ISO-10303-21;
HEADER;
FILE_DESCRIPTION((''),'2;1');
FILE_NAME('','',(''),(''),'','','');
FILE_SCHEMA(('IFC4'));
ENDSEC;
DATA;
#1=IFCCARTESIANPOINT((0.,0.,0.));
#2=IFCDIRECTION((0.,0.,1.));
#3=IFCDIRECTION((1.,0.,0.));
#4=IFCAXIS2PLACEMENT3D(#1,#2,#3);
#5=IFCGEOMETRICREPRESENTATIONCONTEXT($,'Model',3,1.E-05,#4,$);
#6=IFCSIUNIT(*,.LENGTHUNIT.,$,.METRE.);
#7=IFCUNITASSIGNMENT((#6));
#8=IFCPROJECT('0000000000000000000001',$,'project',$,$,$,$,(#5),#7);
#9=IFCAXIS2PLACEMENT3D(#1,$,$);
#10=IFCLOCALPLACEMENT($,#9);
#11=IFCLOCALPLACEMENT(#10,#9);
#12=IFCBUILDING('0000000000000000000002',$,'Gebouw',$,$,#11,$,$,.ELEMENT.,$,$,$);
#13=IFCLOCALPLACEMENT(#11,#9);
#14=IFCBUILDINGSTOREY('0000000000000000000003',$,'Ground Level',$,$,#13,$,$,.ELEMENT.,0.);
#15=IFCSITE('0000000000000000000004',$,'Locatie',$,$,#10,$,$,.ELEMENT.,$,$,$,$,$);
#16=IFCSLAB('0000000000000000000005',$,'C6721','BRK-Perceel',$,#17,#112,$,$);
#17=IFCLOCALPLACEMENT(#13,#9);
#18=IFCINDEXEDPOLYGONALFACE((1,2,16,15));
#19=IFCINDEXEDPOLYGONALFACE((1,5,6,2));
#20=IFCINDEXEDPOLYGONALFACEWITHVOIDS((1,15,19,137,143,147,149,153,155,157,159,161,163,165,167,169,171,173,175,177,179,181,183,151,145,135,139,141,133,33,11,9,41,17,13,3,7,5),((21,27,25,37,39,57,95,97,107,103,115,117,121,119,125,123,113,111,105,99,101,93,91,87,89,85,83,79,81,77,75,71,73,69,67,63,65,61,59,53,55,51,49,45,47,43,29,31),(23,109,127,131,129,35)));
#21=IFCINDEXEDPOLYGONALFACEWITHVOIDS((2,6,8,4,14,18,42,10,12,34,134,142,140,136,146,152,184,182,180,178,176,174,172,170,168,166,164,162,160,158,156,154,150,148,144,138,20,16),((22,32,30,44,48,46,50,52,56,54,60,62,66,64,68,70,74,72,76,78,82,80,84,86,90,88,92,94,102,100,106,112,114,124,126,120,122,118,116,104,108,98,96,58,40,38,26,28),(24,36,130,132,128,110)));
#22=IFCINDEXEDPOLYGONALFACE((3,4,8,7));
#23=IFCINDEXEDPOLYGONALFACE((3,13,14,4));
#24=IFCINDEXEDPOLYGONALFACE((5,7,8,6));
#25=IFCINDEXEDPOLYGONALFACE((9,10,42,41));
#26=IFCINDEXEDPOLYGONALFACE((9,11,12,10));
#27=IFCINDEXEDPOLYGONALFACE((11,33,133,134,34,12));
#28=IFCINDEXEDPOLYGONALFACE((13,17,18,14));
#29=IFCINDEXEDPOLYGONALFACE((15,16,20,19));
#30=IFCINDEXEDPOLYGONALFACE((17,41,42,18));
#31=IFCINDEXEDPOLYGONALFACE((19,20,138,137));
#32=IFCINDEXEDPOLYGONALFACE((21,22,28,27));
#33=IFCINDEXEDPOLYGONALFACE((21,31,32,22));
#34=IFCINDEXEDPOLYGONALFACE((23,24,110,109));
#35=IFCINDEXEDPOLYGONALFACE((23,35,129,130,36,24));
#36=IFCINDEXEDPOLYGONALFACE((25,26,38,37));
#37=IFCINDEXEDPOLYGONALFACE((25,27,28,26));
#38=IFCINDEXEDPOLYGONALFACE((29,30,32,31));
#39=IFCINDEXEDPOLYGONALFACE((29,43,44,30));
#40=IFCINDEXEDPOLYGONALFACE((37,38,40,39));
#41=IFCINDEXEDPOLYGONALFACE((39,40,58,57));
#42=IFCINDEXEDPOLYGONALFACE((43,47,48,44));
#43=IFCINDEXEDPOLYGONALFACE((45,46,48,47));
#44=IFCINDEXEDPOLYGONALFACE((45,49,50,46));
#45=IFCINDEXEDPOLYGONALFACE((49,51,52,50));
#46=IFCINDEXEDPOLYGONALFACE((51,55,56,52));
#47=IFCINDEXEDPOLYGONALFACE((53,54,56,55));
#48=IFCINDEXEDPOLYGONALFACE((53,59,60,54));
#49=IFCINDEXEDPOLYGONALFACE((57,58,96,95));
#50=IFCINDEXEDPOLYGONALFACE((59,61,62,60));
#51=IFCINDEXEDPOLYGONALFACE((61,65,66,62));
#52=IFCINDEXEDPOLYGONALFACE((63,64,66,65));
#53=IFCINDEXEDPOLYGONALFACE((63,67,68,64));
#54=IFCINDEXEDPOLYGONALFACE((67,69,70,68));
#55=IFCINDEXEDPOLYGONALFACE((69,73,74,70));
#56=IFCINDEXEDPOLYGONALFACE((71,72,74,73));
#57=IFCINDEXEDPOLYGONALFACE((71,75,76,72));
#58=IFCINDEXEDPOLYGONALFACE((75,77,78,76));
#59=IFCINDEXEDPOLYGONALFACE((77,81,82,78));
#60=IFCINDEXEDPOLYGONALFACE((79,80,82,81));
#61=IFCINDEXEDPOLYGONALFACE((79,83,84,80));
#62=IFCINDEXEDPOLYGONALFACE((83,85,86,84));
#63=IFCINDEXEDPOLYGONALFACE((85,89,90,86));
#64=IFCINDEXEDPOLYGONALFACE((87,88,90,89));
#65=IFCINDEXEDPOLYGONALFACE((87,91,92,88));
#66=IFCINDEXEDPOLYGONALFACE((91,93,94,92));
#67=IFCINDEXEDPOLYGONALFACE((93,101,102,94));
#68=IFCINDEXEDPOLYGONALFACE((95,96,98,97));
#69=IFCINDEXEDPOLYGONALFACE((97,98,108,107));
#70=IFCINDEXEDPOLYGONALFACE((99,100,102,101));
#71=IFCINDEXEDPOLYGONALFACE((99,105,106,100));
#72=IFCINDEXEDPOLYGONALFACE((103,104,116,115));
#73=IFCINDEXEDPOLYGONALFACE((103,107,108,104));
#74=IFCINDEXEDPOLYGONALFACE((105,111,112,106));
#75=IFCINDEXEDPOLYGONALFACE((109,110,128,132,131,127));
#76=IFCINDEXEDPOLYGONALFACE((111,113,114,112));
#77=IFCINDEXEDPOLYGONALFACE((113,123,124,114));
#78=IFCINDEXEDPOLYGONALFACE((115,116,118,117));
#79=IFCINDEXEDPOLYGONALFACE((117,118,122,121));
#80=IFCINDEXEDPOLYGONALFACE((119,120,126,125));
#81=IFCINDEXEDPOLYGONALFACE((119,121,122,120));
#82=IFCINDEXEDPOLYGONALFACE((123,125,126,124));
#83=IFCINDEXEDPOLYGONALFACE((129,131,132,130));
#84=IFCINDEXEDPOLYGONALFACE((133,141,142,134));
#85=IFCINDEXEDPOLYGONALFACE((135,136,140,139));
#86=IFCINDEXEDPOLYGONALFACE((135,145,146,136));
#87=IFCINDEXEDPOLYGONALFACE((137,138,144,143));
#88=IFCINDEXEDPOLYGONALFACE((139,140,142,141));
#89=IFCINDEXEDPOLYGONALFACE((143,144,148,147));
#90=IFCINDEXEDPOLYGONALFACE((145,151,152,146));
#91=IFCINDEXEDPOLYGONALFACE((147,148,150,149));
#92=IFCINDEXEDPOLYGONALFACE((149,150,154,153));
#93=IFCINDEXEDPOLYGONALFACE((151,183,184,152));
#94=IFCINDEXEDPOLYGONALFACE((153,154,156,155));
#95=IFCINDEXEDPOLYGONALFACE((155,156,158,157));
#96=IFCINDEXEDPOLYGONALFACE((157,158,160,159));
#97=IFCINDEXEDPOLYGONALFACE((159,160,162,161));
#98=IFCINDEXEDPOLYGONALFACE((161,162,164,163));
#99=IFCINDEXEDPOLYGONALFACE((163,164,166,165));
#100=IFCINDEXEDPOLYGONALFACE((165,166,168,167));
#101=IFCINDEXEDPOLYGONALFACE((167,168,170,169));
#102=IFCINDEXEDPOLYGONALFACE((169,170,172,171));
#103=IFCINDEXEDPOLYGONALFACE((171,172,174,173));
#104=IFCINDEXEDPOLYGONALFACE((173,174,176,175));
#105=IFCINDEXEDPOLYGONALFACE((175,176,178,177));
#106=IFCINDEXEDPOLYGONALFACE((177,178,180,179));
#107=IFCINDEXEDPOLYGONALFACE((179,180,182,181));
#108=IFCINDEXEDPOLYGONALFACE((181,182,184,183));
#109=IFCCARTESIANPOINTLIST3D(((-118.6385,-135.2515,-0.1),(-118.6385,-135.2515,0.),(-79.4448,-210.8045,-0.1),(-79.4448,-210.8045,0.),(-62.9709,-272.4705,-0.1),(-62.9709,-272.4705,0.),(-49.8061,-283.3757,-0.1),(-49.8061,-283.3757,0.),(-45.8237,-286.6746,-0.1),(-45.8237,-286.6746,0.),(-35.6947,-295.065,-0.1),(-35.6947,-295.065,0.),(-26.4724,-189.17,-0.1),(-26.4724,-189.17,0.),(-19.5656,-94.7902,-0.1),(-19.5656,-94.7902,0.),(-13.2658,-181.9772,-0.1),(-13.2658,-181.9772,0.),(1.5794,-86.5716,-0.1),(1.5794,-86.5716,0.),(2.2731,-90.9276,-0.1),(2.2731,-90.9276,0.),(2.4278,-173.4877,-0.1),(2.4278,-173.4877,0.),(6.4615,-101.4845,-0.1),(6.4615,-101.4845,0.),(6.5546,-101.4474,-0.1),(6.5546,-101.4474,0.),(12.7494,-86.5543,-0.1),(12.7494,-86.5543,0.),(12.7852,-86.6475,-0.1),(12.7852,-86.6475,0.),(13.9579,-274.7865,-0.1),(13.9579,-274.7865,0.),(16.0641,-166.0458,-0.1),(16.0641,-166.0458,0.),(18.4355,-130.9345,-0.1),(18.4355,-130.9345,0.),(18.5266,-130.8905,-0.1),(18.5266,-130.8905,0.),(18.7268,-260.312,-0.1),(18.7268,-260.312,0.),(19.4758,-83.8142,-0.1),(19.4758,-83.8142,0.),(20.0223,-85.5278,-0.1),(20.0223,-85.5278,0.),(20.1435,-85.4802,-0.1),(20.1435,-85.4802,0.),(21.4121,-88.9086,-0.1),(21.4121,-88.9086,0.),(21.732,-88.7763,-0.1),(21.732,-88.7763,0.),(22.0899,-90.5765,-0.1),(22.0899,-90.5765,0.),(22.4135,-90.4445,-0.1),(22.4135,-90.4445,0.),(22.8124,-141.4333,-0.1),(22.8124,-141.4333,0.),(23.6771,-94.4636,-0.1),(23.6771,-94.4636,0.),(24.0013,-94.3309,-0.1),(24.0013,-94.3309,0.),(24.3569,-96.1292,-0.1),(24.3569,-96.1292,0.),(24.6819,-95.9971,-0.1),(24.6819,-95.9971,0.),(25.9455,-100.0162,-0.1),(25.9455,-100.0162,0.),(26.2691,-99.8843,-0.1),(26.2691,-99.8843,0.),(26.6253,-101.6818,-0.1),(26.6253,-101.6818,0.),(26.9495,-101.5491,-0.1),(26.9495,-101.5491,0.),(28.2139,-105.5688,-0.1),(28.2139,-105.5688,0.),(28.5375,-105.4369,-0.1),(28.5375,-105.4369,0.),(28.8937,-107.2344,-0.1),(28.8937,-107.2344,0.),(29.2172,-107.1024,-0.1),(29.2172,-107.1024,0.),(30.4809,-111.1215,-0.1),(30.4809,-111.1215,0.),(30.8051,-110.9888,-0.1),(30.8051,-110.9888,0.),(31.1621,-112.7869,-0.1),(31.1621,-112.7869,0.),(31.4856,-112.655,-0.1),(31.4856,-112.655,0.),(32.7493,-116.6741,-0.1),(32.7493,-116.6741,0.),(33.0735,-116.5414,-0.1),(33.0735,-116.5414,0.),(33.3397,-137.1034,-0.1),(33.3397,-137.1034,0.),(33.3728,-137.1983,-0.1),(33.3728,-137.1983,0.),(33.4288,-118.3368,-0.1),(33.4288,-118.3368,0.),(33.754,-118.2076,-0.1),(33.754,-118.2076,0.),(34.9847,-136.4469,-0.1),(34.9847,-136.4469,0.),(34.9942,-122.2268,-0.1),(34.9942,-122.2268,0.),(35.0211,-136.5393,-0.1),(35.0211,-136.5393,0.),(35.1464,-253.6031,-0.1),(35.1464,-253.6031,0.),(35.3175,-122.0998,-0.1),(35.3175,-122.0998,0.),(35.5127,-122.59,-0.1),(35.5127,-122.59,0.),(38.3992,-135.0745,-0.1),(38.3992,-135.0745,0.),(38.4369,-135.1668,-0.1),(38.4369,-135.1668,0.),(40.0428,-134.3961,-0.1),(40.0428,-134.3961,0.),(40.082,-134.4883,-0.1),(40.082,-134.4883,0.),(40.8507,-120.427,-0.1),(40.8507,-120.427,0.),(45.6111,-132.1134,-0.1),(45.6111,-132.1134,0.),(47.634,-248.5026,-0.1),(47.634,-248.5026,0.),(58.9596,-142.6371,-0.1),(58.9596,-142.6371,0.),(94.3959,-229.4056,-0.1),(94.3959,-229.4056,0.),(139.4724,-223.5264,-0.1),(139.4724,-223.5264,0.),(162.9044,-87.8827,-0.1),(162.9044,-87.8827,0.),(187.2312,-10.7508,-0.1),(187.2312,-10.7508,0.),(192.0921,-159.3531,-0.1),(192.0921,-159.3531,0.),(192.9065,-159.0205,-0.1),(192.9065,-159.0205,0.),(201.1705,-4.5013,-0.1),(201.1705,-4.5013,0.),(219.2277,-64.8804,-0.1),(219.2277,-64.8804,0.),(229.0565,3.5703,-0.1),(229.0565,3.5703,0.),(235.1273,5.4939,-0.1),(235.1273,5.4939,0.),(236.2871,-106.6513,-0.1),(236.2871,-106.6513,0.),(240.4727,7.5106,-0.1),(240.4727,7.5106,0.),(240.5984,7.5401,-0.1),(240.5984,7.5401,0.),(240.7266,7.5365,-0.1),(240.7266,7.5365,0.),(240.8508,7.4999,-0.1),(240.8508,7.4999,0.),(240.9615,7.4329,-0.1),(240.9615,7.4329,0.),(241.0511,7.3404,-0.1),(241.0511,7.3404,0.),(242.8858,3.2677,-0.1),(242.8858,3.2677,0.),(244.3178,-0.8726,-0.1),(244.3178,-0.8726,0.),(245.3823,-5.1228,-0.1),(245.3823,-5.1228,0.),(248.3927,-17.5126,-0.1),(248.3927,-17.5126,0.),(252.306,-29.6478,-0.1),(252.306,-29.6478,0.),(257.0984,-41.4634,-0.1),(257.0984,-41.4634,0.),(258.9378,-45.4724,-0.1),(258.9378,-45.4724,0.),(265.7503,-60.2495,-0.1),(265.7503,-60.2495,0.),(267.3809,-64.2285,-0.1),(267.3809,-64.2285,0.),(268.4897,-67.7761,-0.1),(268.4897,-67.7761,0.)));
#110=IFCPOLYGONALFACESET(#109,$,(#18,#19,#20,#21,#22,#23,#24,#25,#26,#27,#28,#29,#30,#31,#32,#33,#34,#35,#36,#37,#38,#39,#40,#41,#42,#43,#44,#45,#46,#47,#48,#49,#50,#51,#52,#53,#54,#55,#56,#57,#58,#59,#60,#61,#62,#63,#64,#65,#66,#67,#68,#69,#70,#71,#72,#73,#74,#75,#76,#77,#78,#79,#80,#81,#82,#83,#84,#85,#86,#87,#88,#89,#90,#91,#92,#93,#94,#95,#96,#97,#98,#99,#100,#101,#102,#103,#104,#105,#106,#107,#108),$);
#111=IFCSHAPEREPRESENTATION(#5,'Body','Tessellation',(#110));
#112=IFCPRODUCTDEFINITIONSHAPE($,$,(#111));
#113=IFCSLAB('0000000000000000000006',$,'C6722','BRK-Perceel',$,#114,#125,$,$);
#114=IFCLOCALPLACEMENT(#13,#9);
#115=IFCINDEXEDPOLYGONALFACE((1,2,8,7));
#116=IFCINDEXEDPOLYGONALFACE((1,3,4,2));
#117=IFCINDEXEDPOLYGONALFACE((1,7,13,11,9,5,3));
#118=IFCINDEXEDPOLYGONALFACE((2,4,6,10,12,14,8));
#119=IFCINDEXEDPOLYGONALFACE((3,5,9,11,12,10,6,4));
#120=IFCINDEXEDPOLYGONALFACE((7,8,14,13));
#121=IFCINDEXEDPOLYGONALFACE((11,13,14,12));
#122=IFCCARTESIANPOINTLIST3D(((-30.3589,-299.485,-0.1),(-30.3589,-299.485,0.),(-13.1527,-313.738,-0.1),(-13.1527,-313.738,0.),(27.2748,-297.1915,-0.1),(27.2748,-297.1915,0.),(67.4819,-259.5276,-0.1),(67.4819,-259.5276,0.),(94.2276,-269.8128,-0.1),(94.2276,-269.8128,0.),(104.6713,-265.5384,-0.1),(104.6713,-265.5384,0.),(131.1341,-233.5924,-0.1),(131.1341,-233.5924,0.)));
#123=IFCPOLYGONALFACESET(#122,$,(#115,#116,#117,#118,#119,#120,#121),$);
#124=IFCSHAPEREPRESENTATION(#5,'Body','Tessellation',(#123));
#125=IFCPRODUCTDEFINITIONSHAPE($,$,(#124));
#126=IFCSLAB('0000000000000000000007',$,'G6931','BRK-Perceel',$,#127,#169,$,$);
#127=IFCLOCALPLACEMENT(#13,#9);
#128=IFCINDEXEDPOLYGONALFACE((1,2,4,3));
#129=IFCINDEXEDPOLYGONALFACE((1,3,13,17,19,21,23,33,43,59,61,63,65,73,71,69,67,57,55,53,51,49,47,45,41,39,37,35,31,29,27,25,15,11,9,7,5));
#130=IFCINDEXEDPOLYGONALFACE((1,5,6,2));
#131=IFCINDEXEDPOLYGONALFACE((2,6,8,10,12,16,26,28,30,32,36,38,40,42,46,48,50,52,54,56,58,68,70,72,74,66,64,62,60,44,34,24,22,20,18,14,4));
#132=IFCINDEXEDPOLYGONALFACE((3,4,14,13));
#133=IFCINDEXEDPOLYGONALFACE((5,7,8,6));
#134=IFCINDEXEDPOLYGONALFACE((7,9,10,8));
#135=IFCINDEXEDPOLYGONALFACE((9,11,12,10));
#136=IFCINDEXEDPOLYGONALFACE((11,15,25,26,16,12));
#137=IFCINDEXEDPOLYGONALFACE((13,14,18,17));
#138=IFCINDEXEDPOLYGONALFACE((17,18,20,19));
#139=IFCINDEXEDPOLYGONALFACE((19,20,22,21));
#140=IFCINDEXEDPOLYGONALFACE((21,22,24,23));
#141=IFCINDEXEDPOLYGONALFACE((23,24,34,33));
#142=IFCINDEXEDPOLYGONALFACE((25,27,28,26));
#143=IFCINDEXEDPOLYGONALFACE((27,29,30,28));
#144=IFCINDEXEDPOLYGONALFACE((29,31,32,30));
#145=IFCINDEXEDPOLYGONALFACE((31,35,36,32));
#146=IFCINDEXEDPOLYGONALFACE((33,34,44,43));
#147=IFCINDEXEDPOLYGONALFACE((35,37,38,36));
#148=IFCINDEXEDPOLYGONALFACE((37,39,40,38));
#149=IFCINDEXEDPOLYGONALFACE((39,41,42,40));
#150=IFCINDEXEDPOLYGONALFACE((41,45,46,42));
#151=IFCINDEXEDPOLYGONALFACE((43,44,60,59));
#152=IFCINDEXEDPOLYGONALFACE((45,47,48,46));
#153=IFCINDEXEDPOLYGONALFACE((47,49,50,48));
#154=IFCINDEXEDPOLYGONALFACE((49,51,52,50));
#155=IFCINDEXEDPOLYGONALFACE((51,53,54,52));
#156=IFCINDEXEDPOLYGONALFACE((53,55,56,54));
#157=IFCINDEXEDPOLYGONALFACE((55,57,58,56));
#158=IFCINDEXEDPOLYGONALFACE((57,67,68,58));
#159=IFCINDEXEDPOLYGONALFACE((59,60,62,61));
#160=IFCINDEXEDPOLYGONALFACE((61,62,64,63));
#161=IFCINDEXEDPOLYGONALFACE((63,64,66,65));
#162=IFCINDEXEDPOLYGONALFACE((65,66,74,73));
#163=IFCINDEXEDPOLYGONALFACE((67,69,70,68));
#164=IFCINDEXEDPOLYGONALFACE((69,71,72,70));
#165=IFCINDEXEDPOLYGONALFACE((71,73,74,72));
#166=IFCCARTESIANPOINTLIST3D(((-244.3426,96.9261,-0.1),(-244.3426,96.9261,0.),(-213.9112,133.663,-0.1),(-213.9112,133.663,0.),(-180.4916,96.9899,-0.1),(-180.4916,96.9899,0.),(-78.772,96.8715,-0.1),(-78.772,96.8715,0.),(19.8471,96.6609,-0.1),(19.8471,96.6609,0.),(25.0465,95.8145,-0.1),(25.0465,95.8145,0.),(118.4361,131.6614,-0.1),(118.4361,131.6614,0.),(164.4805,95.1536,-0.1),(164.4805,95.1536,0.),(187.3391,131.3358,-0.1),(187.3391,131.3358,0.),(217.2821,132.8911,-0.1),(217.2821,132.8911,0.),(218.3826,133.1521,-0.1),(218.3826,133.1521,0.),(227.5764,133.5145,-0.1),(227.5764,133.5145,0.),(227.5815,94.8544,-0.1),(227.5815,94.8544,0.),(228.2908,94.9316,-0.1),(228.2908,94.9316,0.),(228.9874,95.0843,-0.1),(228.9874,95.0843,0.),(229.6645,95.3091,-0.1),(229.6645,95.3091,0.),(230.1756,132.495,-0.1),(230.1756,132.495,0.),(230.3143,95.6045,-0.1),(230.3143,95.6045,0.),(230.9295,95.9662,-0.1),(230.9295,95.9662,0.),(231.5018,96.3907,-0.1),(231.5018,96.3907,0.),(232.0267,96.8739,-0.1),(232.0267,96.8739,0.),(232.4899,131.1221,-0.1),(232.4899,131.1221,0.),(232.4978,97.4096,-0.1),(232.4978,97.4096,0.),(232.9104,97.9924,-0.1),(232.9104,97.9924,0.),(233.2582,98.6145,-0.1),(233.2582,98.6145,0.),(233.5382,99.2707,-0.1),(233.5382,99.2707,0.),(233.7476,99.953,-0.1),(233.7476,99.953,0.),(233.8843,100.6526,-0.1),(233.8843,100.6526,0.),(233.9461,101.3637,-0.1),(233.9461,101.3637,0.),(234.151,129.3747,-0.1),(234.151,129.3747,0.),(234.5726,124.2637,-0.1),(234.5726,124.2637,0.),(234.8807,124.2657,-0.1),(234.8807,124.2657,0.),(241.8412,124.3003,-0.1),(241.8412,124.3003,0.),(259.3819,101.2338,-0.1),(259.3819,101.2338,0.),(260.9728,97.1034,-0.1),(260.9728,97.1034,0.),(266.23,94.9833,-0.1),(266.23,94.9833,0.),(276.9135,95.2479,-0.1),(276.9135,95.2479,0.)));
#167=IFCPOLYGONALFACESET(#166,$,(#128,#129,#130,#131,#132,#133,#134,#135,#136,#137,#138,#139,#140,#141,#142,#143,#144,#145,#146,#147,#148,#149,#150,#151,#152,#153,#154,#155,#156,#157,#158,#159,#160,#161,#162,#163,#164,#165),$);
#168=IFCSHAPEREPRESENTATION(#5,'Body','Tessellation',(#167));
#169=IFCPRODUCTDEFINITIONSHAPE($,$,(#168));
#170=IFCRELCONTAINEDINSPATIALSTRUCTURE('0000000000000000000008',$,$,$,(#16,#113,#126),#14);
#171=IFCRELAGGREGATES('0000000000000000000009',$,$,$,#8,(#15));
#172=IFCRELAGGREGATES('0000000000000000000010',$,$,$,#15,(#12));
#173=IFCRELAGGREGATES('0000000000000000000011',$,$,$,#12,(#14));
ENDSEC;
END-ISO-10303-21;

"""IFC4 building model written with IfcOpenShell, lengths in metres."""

from ifc_helpers import new_model, si_unit, frame, origin, origin_with_axes, place, context, project, spatial, polyline, outline, extrude, element, save


model = new_model("IFC4")

# Units and contexts
model_context = context("Model", 3, precision=1e-05, world=origin_with_axes())
ifc_project = project(units=[si_unit("LENGTHUNIT", "METRE")], contexts=[model_context])

# Site, building, storey
site_placement = place(None, origin())
site = spatial("IfcSite", under=ifc_project, at=site_placement, Name="Locatie", CompositionType="ELEMENT")
building_placement = place(site_placement, origin())
building = spatial("IfcBuilding", under=site, at=building_placement, Name="Gebouw", CompositionType="ELEMENT")
storey_placement = place(building_placement, origin())
storey = spatial("IfcBuildingStorey", under=building, at=storey_placement, Name="Ground Level", CompositionType="ELEMENT", Elevation=0.0)

# Slabs
slab_1_placement = place(storey_placement, origin())
element("IfcSlab", 1, at=slab_1_placement, inside=storey, Name="C6721", Description="BRK-Perceel", context=model_context, shape_type="SweptSolid", body=[
    extrude(outline(polyline([(13.9579, -274.7865), (-35.6947, -295.065), (-45.8237, -286.6746), (18.7268, -260.312), (-13.2658, -181.9772), (-26.4724, -189.17), (-79.4448, -210.8045), (-49.8061, -283.3757), (-62.9709, -272.4705), (-118.6385, -135.2515), (-19.5656, -94.7902), (1.5794, -86.5716), (187.2312, -10.7508), (201.1705, -4.5013), (229.0565, 3.5703), (235.1273, 5.4939), (240.4727, 7.5106), (240.5984, 7.5401), (240.7266, 7.5365), (240.8508, 7.4999), (240.9615, 7.4329), (241.0511, 7.3404), (242.8858, 3.2677), (244.3178, -0.8726), (245.3823, -5.1228), (248.3927, -17.5126), (252.306, -29.6478), (257.0984, -41.4634), (258.9378, -45.4724), (265.7503, -60.2495), (267.3809, -64.2285), (268.4897, -67.7761), (236.2871, -106.6513), (219.2277, -64.8804), (162.9044, -87.8827), (192.0921, -159.3531), (192.9065, -159.0205), (139.4724, -223.5264), (13.9579, -274.7865)]), holes=[polyline([(94.3959, -229.4056), (58.9596, -142.6371), (16.0641, -166.0458), (2.4278, -173.4877), (35.1464, -253.6031), (47.634, -248.5026), (94.3959, -229.4056)]), polyline([(33.3397, -137.1034), (33.3728, -137.1983), (35.0211, -136.5393), (34.9847, -136.4469), (38.3992, -135.0745), (38.4369, -135.1668), (40.082, -134.4883), (40.0428, -134.3961), (45.6111, -132.1134), (40.8507, -120.427), (35.5127, -122.59), (35.3175, -122.0998), (34.9942, -122.2268), (33.4288, -118.3368), (33.754, -118.2076), (33.0735, -116.5414), (32.7493, -116.6741), (31.1621, -112.7869), (31.4856, -112.655), (30.8051, -110.9888), (30.4809, -111.1215), (28.8937, -107.2344), (29.2172, -107.1024), (28.5375, -105.4369), (28.2139, -105.5688), (26.6253, -101.6818), (26.9495, -101.5491), (26.2691, -99.8843), (25.9455, -100.0162), (24.3569, -96.1292), (24.6819, -95.9971), (24.0013, -94.3309), (23.6771, -94.4636), (22.0899, -90.5765), (22.4135, -90.4445), (21.732, -88.7763), (21.4121, -88.9086), (20.0223, -85.5278), (20.1435, -85.4802), (19.4758, -83.8142), (12.7494, -86.5543), (12.7852, -86.6475), (2.2731, -90.9276), (6.5546, -101.4474), (6.4615, -101.4845), (18.4355, -130.9345), (18.5266, -130.8905), (22.8124, -141.4333), (33.3397, -137.1034)])]), frame((0.0, 0.0, -0.1), z_axis=(0.0, 0.0, 1.0), x_axis=(1.0, 0.0, 0.0)), (0.0, 0.0, 1.0), 0.1),
])
slab_2_placement = place(storey_placement, origin())
element("IfcSlab", 2, at=slab_2_placement, inside=storey, Name="C6722", Description="BRK-Perceel", context=model_context, shape_type="SweptSolid", body=[
    extrude(outline(polyline([(67.4819, -259.5276), (131.1341, -233.5924), (104.6713, -265.5384), (94.2276, -269.8128), (27.2748, -297.1915), (-13.1527, -313.738), (-30.3589, -299.485), (67.4819, -259.5276)])), frame((0.0, 0.0, -0.1), z_axis=(0.0, 0.0, 1.0), x_axis=(1.0, 0.0, 0.0)), (0.0, 0.0, 1.0), 0.1),
])
slab_3_placement = place(storey_placement, origin())
element("IfcSlab", 3, at=slab_3_placement, inside=storey, Name="G6931", Description="BRK-Perceel", context=model_context, shape_type="SweptSolid", body=[
    extrude(outline(polyline([(266.23, 94.9833), (260.9728, 97.1034), (259.3819, 101.2338), (233.9461, 101.3637), (233.8843, 100.6526), (233.7476, 99.953), (233.5382, 99.2707), (233.2582, 98.6145), (232.9104, 97.9924), (232.4978, 97.4096), (232.0267, 96.8739), (231.5018, 96.3907), (230.9295, 95.9662), (230.3143, 95.6045), (229.6645, 95.3091), (228.9874, 95.0843), (228.2908, 94.9316), (227.5815, 94.8544), (164.4805, 95.1536), (25.0465, 95.8145), (19.8471, 96.6609), (-78.772, 96.8715), (-180.4916, 96.9899), (-244.3426, 96.9261), (-213.9112, 133.663), (118.4361, 131.6614), (187.3391, 131.3358), (217.2821, 132.8911), (218.3826, 133.1521), (227.5764, 133.5145), (230.1756, 132.495), (232.4899, 131.1221), (234.151, 129.3747), (234.5726, 124.2637), (234.8807, 124.2657), (241.8412, 124.3003), (276.9135, 95.2479), (266.23, 94.9833)])), frame((0.0, 0.0, -0.1), z_axis=(0.0, 0.0, 1.0), x_axis=(1.0, 0.0, 0.0)), (0.0, 0.0, 1.0), 0.1),
])

save(model, "model.ifc")
